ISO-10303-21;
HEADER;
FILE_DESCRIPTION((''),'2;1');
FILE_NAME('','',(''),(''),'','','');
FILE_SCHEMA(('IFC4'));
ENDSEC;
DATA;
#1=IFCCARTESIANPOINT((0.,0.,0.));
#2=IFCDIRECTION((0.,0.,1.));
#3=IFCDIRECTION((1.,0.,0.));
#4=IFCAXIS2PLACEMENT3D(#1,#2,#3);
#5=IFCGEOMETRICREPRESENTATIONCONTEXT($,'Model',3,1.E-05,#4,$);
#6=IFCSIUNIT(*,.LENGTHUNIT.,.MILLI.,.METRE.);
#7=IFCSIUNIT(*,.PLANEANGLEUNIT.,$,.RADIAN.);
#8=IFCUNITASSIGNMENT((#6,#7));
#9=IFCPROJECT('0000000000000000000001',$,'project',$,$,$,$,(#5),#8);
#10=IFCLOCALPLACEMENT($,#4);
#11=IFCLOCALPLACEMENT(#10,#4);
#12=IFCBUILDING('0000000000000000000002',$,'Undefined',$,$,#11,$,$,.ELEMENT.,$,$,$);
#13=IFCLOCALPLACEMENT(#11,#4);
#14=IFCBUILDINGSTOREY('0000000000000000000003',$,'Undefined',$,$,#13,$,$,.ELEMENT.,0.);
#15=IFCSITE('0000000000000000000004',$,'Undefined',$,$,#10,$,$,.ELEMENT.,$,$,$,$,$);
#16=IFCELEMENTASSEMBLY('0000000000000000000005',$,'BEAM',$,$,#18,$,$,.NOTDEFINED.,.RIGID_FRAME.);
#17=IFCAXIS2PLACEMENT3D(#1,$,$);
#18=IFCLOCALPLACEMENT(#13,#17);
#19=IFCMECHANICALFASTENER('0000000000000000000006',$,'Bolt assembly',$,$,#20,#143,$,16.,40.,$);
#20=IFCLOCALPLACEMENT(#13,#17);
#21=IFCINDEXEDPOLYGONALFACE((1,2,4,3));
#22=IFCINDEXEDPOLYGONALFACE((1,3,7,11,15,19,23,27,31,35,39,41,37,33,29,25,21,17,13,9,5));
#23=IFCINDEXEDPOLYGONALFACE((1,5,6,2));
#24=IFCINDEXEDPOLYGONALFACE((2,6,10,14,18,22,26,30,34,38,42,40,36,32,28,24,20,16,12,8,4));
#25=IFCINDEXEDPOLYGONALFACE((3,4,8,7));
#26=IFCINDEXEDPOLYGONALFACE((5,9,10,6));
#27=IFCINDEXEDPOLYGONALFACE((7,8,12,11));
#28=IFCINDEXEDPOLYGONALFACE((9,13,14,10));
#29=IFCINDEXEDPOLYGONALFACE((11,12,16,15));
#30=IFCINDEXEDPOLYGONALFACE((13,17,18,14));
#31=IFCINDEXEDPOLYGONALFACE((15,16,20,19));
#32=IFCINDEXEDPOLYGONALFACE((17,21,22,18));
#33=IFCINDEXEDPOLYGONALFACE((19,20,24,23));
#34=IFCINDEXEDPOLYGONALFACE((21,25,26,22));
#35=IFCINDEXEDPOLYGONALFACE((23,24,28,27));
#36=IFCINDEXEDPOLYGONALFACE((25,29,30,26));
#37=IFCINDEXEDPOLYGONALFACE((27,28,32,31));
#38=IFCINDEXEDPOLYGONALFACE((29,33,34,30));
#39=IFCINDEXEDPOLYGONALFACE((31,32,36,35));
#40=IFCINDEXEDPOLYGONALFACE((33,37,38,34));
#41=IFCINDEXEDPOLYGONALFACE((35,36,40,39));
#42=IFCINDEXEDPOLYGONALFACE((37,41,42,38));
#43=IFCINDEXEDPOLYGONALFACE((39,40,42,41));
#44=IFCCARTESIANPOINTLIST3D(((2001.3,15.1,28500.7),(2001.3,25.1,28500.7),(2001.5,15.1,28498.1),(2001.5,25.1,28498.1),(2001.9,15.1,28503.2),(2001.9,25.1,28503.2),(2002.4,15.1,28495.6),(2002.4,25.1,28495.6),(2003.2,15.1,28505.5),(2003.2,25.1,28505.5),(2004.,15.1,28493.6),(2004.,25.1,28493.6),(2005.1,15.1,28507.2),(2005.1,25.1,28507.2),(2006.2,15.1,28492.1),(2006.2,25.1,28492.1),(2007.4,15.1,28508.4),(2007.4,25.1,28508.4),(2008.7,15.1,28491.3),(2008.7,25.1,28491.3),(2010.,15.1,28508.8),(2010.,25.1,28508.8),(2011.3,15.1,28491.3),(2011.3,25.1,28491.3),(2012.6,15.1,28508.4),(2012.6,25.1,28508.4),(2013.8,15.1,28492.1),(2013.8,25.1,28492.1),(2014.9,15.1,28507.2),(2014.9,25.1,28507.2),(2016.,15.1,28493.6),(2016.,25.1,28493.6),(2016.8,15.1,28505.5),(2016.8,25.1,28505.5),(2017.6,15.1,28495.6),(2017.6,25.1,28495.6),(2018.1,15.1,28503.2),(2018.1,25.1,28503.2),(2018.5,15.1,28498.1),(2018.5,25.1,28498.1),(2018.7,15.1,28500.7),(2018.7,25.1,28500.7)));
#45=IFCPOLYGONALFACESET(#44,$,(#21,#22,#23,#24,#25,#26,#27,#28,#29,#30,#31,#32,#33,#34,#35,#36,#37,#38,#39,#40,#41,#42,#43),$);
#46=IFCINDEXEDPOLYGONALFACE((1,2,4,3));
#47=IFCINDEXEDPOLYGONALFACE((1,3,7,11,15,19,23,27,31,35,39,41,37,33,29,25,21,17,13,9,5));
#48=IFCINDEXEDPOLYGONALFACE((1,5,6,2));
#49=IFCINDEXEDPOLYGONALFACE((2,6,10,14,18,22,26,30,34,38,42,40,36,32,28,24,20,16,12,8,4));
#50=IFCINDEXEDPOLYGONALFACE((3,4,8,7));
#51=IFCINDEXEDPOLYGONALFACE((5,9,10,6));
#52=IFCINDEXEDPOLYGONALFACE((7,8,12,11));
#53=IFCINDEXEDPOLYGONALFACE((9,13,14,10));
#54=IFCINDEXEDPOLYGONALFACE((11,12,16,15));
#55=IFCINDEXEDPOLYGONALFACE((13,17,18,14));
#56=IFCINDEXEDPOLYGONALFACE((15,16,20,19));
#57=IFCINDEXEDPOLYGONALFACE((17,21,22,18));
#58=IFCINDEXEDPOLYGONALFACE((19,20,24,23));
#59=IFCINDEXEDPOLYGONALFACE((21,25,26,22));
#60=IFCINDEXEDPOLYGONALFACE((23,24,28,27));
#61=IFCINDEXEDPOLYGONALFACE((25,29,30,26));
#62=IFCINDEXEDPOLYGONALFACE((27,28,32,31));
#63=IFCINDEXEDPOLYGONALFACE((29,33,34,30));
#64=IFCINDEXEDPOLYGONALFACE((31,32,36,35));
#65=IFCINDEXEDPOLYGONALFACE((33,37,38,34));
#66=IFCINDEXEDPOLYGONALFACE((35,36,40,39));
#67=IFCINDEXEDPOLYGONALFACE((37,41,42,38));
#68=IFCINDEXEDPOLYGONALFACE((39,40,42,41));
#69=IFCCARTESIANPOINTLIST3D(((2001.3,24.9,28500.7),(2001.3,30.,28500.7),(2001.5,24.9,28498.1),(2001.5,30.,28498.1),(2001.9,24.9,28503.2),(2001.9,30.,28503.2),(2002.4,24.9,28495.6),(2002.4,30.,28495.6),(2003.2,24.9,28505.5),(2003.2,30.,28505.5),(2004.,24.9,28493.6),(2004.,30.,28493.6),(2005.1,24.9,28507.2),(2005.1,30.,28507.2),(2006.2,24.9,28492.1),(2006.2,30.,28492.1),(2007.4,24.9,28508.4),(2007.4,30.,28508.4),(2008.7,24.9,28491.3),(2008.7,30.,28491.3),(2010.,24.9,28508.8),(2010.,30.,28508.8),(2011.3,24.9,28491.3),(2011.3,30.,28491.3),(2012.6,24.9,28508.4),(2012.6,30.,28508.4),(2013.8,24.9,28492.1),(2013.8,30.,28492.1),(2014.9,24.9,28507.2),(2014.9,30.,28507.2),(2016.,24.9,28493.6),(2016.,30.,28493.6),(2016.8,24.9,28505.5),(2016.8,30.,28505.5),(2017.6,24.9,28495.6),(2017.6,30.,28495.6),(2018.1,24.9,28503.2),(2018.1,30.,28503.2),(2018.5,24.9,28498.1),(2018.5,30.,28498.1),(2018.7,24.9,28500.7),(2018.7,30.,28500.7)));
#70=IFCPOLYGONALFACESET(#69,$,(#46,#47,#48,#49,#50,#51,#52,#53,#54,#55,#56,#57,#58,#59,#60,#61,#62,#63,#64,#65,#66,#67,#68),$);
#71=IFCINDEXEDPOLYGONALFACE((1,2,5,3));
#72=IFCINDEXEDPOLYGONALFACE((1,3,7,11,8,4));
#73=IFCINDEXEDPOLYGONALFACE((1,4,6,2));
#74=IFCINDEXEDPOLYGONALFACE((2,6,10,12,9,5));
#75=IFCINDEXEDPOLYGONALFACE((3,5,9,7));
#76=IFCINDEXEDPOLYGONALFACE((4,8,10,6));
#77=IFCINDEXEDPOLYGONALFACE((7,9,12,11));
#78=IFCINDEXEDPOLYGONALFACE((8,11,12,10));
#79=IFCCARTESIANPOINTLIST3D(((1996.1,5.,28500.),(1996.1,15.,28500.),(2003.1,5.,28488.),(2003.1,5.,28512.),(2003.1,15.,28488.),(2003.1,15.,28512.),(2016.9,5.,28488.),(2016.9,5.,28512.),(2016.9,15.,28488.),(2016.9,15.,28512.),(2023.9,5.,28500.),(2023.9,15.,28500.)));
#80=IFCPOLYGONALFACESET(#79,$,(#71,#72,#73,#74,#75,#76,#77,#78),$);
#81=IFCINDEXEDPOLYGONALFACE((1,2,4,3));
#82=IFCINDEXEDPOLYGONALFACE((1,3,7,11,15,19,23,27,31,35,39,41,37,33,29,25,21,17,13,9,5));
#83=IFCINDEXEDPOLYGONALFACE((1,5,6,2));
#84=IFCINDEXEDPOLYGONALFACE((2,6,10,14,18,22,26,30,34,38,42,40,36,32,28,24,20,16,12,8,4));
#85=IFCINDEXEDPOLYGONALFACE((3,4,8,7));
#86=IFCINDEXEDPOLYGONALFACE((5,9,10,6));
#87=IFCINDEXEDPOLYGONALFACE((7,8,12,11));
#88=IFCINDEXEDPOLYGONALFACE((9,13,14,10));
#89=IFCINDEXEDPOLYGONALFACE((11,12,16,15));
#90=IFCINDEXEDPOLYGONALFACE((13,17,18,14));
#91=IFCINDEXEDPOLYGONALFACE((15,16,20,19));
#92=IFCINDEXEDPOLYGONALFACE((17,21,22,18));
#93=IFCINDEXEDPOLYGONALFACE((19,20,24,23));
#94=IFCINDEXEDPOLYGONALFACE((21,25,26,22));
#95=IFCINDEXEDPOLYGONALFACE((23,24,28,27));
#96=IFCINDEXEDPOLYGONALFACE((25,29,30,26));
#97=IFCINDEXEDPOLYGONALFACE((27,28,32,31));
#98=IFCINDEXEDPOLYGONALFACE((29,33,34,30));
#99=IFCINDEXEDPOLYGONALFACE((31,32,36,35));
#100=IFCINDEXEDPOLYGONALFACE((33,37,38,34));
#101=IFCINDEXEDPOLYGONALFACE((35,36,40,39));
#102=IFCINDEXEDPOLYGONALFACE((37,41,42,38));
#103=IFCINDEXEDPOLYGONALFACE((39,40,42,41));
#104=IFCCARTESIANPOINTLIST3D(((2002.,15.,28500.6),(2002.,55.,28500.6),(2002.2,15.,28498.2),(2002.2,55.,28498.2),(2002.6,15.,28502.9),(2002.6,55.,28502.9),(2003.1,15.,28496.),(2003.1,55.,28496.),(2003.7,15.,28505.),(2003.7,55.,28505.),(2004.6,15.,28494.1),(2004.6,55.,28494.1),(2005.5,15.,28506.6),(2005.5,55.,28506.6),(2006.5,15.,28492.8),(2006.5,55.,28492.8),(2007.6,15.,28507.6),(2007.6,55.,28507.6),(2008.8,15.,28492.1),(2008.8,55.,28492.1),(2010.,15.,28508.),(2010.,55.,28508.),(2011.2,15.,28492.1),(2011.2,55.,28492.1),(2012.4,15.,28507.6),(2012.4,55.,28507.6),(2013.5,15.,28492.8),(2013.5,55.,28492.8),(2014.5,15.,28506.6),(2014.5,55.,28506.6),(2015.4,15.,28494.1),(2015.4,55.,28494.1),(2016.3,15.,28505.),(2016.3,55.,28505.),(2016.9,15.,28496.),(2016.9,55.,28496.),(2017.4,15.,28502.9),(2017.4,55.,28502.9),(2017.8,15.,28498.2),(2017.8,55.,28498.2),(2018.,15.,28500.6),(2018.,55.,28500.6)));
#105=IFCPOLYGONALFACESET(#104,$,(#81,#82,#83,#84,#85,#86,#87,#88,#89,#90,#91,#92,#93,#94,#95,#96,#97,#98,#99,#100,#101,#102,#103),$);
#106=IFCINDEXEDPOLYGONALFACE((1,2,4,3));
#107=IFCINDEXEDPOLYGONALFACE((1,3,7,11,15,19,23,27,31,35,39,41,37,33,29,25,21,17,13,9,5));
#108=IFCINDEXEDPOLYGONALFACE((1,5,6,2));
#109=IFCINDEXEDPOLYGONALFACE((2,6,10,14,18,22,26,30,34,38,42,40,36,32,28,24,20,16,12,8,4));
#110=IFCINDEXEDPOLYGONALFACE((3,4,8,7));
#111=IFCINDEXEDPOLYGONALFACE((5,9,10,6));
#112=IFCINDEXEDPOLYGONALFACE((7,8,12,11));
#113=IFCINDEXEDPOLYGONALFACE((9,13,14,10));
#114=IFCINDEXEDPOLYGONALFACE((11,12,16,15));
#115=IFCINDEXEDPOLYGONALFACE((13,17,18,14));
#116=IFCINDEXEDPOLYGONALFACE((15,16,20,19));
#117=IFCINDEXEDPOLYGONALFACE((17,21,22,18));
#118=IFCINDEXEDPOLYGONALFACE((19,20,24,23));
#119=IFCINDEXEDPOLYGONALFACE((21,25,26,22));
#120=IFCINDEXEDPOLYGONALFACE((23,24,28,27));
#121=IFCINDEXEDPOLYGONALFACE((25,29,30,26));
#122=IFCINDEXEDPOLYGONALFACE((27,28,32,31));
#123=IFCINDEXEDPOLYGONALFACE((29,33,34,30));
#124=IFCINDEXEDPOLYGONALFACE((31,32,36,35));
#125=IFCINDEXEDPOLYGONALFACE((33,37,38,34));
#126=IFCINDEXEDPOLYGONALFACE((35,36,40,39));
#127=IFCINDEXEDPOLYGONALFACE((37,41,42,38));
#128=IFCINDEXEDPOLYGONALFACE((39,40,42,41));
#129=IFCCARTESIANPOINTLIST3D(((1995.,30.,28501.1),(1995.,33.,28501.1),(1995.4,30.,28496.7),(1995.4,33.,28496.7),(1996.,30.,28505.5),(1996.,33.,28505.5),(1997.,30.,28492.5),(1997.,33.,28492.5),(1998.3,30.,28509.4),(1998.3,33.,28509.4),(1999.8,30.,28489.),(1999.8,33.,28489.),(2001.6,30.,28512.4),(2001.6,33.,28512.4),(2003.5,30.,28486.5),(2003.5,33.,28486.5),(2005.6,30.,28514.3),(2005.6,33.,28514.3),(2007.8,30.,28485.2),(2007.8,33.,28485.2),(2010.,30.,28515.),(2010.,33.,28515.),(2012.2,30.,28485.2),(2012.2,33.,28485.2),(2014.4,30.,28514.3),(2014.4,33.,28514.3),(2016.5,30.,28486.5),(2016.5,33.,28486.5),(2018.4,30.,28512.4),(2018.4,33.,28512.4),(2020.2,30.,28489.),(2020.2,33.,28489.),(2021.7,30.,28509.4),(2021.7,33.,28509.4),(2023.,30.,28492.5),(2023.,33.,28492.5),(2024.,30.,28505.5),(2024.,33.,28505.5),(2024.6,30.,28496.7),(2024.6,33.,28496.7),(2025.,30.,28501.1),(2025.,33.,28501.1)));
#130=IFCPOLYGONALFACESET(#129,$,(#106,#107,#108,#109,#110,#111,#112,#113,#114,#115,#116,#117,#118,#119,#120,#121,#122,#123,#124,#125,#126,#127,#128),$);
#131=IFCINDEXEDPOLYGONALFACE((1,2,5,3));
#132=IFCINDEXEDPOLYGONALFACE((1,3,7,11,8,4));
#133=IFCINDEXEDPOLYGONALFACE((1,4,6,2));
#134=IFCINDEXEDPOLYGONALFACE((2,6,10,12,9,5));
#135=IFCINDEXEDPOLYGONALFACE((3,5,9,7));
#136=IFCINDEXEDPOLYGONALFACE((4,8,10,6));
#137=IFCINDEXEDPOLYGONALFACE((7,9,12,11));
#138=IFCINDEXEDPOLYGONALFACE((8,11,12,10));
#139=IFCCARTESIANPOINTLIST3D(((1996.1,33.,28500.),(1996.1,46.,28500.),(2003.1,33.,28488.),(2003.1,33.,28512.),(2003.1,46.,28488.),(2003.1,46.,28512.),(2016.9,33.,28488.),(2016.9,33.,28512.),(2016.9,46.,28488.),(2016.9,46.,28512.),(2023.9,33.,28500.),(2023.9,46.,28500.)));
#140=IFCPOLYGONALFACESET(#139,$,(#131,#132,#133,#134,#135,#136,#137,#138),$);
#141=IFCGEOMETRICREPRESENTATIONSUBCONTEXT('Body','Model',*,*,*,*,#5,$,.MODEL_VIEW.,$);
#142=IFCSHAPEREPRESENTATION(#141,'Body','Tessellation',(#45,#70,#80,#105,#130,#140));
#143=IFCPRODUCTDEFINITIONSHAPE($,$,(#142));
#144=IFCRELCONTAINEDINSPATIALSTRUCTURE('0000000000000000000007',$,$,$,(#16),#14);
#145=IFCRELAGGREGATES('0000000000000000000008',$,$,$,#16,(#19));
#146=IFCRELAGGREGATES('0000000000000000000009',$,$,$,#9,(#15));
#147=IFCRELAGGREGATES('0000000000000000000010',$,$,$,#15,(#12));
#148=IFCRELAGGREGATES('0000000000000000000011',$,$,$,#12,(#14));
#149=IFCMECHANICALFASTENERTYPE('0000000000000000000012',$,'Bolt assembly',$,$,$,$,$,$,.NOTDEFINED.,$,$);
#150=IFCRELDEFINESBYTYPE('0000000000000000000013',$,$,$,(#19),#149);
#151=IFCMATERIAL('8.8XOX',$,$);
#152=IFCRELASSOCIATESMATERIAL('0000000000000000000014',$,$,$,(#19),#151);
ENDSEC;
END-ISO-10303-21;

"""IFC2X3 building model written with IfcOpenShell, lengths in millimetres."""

from ifc_helpers import new_model, si_unit, frame, origin_with_axes, origin_2d_with_axis, place, context, subcontext, project, spatial, polyline, circle, outline, extrude, source, transform, mapped, material, type_object, element, aggregate, save


model = new_model("IFC2X3")

# Units and contexts
model_context = context("Model", 3, precision=1e-05, world=origin_with_axes())
body_context = subcontext(model_context, "Body", "Model", "MODEL_VIEW")
ifc_project = project(units=[si_unit("LENGTHUNIT", "METRE", prefix="MILLI"), si_unit("PLANEANGLEUNIT", "RADIAN")], contexts=[model_context])

# Site, building, storey
site_placement = place(None, origin_with_axes())
site = spatial("IfcSite", under=ifc_project, at=site_placement, Name="Undefined", CompositionType="ELEMENT")
building_placement = place(site_placement, origin_with_axes())
building = spatial("IfcBuilding", under=site, at=building_placement, Name="Undefined", CompositionType="ELEMENT")
storey_placement = place(building_placement, origin_with_axes())
storey = spatial("IfcBuildingStorey", under=building, at=storey_placement, Name="Undefined", CompositionType="ELEMENT", Elevation=0.0)

# Element assembly
assembly_1_placement = place(storey_placement, origin_with_axes())
assembly_1 = element("IfcElementAssembly", 1, at=assembly_1_placement, inside=storey, Name="BEAM", AssemblyPlace="NOTDEFINED", PredefinedType="RIGID_FRAME")

# Mechanical fastener
ifc_material_1 = material(Name="8.8XOX")
mechanical_fastener_type = type_object("IfcMechanicalFastenerType", Name="Bolt assembly")
shared_shape_1 = source(origin_with_axes(), body_context, "Body", "SweptSolid", [
    extrude(circle(Radius=8.8, at=origin_2d_with_axis()), frame((0.0, 15.1, 0.0), z_axis=(0.0, 1.0, 0.0), x_axis=(1.0, 0.0, 0.0)), (0.0, 0.0, 1.0), 10.0),
    extrude(circle(Radius=8.8, at=origin_2d_with_axis()), frame((0.0, 24.9, 0.0), z_axis=(0.0, 1.0, 0.0), x_axis=(1.0, 0.0, 0.0)), (0.0, 0.0, 1.0), 5.1),
    extrude(outline(polyline([(12.0, -6.9), (12.0, 6.9), (0.0, 13.9), (-12.0, 6.9), (-12.0, -6.9), (0.0, -13.9), (12.0, -6.9)])), frame((0.0, 5.0, 0.0), z_axis=(0.0, 1.0, 0.0), x_axis=(1.0, 0.0, 0.0)), (0.0, 0.0, 1.0), 10.0),
    extrude(circle(Radius=8.0, at=origin_2d_with_axis()), frame((0.0, 15.0, 0.0), z_axis=(0.0, 1.0, 0.0), x_axis=(1.0, 0.0, 0.0)), (0.0, 0.0, 1.0), 40.0),
    extrude(circle(Radius=15.0, at=origin_2d_with_axis()), frame((0.0, 30.0, 0.0), z_axis=(0.0, 1.0, 0.0), x_axis=(1.0, 0.0, 0.0)), (0.0, 0.0, 1.0), 3.0),
    extrude(outline(polyline([(12.0, -6.9), (12.0, 6.9), (0.0, 13.9), (-12.0, 6.9), (-12.0, -6.9), (0.0, -13.9), (12.0, -6.9)])), frame((0.0, 33.0, 0.0), z_axis=(0.0, 1.0, 0.0), x_axis=(1.0, 0.0, 0.0)), (0.0, 0.0, 1.0), 13.0),
])
mechanical_fastener_1_placement = place(assembly_1_placement, frame((2010.0, 0.0, 28500.0), z_axis=(-1.0, 0.0, 0.0), x_axis=(0.0, 0.0, 1.0)))
mechanical_fastener_1 = element("IfcMechanicalFastener", 2, at=mechanical_fastener_1_placement, type_object=mechanical_fastener_type, material=ifc_material_1, Name="Bolt assembly", NominalDiameter=16.0, NominalLength=40.0, context=body_context, shape_type="MappedRepresentation", body=[
    mapped(shared_shape_1, transform((0.0, 0.0, 0.0))),
])
aggregate(assembly_1, [mechanical_fastener_1])

save(model, "model.ifc")
